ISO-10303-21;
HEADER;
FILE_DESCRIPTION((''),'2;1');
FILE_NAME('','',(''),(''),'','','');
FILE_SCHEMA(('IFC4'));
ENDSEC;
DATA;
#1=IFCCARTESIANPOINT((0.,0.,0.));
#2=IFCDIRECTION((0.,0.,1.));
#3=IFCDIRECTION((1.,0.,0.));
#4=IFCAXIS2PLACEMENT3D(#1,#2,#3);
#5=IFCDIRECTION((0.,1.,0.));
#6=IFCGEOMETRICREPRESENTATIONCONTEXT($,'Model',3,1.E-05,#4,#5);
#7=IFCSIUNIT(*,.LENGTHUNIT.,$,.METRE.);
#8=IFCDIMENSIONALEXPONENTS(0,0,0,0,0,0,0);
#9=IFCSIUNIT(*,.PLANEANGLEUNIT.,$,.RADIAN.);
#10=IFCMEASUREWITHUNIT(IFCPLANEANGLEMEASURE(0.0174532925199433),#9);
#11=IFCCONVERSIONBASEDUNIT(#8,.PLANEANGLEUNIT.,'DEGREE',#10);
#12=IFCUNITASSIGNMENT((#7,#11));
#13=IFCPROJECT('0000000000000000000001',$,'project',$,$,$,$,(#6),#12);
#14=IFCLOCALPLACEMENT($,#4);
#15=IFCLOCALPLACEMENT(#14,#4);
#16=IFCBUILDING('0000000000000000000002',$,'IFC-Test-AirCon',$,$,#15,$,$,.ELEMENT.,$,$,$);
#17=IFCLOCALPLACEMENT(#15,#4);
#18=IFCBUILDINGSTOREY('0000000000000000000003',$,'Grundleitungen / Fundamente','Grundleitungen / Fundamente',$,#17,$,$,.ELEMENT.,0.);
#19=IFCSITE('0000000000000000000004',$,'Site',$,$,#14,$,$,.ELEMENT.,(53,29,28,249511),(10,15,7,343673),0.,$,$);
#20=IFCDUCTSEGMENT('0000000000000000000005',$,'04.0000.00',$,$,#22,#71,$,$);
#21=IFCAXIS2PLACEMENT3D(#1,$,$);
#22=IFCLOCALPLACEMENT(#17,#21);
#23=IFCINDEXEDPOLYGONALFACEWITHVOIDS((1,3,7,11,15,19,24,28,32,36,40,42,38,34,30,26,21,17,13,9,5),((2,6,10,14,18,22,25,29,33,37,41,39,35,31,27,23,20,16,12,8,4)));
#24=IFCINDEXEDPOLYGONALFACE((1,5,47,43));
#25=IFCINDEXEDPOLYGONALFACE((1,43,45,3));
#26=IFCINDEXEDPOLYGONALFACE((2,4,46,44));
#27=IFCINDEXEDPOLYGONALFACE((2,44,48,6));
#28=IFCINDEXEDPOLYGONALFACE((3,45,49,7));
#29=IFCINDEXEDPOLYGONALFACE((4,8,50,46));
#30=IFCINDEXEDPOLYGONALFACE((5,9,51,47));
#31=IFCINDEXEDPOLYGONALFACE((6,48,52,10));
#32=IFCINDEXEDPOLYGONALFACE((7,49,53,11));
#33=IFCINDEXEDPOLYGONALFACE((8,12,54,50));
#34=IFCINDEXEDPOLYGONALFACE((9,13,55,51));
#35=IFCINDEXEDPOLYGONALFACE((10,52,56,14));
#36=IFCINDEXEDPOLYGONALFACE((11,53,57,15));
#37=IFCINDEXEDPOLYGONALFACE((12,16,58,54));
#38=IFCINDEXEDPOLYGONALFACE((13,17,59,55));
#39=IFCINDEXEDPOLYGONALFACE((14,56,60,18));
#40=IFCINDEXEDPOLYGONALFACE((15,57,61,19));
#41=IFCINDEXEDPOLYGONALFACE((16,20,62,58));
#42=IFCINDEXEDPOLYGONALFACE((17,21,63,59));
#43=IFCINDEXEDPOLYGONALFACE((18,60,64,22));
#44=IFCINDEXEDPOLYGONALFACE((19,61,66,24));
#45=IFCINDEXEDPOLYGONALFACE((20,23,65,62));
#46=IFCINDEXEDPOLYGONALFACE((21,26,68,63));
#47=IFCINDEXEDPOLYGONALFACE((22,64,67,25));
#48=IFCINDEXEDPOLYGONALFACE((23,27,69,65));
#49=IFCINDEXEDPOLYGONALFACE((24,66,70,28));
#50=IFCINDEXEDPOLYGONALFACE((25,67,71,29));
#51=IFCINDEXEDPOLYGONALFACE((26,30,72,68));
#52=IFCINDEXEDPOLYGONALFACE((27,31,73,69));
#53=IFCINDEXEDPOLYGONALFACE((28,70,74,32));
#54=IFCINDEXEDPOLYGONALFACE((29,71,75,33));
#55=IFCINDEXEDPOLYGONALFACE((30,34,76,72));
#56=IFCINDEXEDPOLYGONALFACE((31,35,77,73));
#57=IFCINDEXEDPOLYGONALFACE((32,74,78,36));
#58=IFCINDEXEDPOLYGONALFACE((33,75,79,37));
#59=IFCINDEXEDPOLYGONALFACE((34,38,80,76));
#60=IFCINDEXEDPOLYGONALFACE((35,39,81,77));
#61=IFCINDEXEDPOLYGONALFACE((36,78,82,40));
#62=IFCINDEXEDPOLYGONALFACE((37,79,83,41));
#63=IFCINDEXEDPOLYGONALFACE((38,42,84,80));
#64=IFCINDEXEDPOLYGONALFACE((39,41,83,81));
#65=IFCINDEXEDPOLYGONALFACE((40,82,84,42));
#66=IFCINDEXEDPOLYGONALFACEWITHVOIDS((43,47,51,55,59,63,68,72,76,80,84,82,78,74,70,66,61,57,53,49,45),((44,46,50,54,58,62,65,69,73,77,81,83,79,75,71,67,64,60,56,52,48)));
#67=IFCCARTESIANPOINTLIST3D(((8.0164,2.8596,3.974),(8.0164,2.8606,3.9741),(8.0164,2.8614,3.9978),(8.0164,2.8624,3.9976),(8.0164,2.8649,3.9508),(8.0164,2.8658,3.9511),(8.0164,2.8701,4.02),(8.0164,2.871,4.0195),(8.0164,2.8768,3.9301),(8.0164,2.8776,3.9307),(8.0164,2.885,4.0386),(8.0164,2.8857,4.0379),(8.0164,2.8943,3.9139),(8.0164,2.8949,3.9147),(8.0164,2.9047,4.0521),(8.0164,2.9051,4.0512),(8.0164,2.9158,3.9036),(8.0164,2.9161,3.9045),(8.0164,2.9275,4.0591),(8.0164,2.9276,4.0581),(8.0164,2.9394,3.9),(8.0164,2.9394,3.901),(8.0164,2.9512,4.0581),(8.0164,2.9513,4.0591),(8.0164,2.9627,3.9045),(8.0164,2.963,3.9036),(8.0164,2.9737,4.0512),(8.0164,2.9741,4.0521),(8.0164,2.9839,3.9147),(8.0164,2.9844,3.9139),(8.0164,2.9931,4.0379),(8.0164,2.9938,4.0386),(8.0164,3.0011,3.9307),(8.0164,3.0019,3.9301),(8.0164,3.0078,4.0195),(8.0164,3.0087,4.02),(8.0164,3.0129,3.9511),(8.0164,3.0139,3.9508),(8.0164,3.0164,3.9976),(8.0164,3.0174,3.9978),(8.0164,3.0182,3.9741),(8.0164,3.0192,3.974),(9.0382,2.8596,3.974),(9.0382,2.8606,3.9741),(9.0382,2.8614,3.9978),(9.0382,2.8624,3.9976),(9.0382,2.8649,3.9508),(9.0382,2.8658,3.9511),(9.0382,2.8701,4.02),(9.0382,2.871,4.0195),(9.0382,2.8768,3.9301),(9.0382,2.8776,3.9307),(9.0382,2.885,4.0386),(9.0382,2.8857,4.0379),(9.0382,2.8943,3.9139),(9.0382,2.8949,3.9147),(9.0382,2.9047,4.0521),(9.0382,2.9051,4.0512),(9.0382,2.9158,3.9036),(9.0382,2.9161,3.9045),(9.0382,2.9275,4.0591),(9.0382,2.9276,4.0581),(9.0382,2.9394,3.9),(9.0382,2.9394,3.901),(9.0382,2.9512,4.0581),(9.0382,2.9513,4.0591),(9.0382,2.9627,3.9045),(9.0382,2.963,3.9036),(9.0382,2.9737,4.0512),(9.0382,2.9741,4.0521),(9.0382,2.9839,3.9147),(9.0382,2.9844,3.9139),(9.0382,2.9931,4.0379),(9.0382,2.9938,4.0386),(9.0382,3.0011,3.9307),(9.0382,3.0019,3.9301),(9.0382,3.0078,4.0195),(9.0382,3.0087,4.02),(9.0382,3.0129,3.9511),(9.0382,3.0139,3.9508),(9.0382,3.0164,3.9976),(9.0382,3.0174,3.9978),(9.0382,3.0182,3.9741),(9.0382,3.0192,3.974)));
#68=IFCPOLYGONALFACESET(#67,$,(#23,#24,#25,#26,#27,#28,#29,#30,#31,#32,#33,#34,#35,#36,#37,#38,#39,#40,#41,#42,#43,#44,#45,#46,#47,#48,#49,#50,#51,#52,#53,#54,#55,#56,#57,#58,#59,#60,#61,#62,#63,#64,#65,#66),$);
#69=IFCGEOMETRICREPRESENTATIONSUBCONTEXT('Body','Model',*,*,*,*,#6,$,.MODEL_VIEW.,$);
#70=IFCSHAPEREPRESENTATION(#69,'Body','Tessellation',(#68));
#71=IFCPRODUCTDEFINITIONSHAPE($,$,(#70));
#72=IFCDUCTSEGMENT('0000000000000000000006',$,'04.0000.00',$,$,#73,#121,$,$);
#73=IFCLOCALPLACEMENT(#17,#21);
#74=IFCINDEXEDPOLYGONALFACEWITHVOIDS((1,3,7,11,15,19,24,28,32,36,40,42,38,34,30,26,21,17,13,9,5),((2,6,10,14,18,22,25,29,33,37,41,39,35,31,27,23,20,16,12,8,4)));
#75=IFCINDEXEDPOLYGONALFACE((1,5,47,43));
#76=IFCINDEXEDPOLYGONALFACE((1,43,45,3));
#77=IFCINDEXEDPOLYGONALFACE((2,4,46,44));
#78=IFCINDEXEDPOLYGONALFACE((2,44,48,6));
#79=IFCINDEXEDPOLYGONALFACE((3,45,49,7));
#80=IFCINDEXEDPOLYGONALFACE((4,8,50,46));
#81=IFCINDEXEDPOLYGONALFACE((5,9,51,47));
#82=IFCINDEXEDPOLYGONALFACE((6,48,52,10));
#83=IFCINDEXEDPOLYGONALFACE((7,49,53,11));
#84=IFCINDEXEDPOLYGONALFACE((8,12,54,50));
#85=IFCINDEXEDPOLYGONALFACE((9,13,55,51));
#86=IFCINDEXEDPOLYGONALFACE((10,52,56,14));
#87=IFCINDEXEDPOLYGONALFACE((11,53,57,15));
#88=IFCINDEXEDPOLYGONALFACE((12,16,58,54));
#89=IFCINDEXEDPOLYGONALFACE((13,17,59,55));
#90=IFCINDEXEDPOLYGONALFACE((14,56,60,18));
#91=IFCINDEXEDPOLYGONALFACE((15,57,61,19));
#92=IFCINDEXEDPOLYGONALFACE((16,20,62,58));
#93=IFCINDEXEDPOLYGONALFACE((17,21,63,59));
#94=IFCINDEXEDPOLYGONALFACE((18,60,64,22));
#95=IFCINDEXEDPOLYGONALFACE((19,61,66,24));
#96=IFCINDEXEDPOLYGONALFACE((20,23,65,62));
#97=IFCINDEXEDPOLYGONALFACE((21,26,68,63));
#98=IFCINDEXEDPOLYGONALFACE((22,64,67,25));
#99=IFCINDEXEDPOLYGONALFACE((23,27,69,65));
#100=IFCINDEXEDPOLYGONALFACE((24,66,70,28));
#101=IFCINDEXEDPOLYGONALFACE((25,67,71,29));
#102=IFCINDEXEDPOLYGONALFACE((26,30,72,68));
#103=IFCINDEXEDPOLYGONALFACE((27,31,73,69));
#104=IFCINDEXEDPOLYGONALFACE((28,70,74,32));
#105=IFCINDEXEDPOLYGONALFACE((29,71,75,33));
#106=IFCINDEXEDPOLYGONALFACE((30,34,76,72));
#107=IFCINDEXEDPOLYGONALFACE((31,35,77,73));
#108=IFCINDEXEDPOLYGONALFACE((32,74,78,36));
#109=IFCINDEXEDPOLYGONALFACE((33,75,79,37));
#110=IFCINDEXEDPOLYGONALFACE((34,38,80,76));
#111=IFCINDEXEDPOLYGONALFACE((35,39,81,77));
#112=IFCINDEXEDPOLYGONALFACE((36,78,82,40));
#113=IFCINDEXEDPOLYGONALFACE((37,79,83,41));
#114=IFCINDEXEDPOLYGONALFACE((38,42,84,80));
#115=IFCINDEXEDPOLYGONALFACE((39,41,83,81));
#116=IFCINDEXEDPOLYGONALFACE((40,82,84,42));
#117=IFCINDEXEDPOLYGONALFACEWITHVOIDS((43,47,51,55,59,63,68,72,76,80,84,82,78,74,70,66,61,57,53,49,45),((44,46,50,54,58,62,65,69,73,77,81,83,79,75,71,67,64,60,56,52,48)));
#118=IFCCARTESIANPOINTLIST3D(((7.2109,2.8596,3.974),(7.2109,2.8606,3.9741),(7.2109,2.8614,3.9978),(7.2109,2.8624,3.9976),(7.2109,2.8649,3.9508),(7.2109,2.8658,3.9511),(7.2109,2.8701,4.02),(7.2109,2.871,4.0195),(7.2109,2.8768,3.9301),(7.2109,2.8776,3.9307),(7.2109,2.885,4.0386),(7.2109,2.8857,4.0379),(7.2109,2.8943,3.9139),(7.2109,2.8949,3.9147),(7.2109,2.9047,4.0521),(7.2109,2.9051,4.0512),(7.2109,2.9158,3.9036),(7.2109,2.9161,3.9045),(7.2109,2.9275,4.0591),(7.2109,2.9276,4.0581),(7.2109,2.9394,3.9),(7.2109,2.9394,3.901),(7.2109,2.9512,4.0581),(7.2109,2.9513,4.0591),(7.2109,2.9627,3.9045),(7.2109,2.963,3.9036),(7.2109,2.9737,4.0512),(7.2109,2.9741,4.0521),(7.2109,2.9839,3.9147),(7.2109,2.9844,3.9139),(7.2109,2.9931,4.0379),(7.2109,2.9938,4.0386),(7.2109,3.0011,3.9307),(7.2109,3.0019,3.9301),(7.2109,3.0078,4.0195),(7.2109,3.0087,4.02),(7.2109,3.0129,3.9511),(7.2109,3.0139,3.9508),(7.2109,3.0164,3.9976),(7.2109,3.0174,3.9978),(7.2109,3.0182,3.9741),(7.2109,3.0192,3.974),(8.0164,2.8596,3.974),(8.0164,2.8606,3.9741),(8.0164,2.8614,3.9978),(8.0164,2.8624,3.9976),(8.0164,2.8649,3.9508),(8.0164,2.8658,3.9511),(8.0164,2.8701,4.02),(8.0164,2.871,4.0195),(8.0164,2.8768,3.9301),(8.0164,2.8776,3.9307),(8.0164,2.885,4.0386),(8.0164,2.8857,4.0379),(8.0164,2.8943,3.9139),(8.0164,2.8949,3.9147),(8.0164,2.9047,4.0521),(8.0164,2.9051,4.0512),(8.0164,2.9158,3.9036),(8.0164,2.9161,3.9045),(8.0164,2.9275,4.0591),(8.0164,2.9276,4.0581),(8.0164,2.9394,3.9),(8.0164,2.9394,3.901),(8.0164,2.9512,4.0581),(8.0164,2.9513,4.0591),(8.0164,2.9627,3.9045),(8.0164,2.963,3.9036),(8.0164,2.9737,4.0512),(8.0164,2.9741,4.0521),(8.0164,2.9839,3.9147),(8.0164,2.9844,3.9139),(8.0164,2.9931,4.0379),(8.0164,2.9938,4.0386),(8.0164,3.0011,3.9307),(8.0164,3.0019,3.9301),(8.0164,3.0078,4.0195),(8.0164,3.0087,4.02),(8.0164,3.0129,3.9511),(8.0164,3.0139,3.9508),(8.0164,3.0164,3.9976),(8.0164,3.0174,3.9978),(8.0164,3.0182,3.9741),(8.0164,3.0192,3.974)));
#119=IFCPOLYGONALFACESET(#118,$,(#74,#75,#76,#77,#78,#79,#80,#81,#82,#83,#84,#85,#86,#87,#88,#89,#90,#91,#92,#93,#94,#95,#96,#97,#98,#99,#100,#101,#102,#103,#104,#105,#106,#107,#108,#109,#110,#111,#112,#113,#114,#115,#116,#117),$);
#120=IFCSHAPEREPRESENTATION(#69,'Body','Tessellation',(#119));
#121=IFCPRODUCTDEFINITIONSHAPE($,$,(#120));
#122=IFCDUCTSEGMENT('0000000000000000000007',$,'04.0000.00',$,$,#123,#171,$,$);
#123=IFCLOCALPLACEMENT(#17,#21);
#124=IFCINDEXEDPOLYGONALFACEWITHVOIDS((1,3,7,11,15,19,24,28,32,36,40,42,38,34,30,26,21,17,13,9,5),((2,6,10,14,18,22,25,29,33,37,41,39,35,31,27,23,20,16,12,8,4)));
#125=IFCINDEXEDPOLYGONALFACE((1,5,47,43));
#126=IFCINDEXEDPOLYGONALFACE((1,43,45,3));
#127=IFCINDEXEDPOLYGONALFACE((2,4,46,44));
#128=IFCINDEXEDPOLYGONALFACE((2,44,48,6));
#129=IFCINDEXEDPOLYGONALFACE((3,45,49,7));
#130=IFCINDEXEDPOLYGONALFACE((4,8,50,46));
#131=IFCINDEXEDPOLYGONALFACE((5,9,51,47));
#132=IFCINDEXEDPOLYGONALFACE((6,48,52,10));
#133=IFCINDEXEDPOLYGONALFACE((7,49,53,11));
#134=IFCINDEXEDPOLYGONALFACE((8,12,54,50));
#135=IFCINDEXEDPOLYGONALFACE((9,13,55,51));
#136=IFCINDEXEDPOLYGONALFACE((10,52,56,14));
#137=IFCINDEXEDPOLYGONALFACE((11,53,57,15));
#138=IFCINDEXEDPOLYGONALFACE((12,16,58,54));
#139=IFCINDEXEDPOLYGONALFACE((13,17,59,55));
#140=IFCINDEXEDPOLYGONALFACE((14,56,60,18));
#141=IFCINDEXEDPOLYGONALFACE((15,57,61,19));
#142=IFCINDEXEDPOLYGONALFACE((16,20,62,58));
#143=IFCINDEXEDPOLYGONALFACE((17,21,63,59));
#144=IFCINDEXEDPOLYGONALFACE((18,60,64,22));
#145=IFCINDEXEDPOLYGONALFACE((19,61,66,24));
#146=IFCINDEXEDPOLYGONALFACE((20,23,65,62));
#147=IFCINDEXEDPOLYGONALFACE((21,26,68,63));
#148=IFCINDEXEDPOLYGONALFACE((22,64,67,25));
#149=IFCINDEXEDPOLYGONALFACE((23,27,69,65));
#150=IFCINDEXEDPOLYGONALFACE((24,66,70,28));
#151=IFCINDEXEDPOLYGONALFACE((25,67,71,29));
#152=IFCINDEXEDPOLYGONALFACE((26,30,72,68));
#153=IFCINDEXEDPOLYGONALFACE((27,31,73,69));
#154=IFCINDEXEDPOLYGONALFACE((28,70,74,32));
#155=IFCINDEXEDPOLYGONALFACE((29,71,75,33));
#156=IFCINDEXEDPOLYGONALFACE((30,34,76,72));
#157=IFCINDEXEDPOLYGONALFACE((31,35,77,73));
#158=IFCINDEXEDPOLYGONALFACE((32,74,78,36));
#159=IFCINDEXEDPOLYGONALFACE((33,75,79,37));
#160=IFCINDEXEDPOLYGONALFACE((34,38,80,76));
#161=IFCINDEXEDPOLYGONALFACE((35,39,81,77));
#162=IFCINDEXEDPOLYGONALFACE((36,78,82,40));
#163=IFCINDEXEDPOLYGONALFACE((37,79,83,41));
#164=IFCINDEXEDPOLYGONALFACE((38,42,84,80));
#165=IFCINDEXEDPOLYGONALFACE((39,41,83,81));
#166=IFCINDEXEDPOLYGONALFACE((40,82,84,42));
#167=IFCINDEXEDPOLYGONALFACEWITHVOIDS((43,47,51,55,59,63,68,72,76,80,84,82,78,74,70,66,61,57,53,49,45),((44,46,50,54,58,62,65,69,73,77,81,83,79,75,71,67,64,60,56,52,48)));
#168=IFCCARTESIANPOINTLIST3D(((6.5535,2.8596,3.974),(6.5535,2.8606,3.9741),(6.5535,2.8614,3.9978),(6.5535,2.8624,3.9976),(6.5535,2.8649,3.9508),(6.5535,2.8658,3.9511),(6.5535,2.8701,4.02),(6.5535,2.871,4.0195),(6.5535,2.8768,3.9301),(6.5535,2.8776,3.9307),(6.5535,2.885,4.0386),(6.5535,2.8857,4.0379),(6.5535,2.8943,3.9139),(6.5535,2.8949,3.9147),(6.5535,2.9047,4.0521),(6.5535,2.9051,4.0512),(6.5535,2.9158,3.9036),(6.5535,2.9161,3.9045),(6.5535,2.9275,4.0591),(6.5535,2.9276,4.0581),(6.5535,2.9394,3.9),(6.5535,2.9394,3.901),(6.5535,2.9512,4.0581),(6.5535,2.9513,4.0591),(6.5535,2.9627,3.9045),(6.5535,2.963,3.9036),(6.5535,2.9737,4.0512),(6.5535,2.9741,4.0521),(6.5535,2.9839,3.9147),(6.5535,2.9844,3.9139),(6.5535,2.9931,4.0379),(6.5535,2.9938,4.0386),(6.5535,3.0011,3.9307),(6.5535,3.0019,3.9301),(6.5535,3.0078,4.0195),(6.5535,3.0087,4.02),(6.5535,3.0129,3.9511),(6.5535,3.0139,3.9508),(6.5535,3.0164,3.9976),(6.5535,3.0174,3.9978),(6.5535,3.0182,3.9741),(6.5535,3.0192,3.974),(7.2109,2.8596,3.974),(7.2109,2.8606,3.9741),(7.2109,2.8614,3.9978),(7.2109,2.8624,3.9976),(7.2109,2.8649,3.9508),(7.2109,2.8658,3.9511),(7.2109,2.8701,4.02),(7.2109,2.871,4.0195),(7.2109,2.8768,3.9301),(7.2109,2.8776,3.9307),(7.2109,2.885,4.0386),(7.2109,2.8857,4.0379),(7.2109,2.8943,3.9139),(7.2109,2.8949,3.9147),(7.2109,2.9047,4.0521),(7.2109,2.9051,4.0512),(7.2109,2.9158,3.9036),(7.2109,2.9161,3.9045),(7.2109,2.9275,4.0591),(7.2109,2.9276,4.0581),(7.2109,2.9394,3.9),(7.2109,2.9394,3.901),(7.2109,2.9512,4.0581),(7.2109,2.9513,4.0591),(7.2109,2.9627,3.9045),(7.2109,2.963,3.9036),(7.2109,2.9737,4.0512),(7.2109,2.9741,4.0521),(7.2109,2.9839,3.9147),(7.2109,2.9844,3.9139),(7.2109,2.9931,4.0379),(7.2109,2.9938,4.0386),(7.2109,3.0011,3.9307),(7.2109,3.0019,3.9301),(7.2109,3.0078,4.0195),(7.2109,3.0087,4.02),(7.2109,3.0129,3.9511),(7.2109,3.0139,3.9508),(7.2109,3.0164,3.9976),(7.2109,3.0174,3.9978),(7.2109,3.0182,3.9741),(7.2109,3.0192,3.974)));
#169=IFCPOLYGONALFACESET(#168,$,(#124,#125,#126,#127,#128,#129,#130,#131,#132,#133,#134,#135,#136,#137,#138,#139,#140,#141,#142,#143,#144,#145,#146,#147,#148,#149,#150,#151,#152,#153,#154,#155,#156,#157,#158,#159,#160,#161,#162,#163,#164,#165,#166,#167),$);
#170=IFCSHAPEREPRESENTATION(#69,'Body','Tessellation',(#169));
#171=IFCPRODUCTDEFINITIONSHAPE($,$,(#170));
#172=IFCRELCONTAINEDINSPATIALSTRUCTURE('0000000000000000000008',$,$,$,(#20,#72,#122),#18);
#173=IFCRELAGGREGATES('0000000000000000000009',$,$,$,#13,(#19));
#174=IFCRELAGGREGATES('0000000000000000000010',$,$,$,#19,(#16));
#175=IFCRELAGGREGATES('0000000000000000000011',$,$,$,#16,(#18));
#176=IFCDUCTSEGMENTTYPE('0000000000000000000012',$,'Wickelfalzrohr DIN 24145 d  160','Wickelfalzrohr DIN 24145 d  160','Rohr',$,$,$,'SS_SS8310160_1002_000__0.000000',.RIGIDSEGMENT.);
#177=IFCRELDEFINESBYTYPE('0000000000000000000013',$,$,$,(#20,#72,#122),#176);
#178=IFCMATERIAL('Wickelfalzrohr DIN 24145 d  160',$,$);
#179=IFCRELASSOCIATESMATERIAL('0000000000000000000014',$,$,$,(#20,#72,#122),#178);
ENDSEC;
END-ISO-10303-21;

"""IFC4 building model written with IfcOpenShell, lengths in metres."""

from ifc_helpers import new_model, entity, si_unit, converted_unit, direction, frame, origin_with_axes, origin_2d_with_axis, place, context, subcontext, project, spatial, hollow_circle, extrude, material, type_object, element, save


model = new_model("IFC4")

# Units and contexts
model_context = context("Model", 3, precision=1e-05, world=origin_with_axes(), true_north=direction((0.0, 1.0, 0.0)))
body_context = subcontext(model_context, "Body", "Model", "MODEL_VIEW")
ifc_project = project(units=[si_unit("LENGTHUNIT", "METRE"), converted_unit("PLANEANGLEUNIT", "DEGREE", entity("IfcPlaneAngleMeasure", 0.0174532925199433), si_unit("PLANEANGLEUNIT", "RADIAN"), dimensions=[0, 0, 0, 0, 0, 0, 0])], contexts=[model_context])

# Site, building, storey
site_placement = place(None, origin_with_axes())
site = spatial("IfcSite", under=ifc_project, at=site_placement, Name="Site", CompositionType="ELEMENT", RefLatitude=(53, 29, 28, 249511), RefLongitude=(10, 15, 7, 343673), RefElevation=0.0)
building_placement = place(site_placement, origin_with_axes())
building = spatial("IfcBuilding", under=site, at=building_placement, Name="IFC-Test-AirCon", CompositionType="ELEMENT")
storey_placement = place(building_placement, origin_with_axes())
storey = spatial("IfcBuildingStorey", under=building, at=storey_placement, Name="Grundleitungen / Fundamente", Description="Grundleitungen / Fundamente", CompositionType="ELEMENT", Elevation=0.0)

# Duct segments
ifc_material_1 = material(Name="Wickelfalzrohr DIN 24145 d  160")
duct_segment_type_1 = type_object("IfcDuctSegmentType", Name="Wickelfalzrohr DIN 24145 d  160", Description="Wickelfalzrohr DIN 24145 d  160", ApplicableOccurrence="Rohr", ElementType="SS_SS8310160_1002_000__0.000000", PredefinedType="RIGIDSEGMENT")
duct_segment_1_placement = place(storey_placement, frame((9.0382, 2.9394, 3.98), z_axis=(0.0, 0.0, 1.0), x_axis=(-1.0, 0.0, 0.0)))
element("IfcDuctSegment", 1, at=duct_segment_1_placement, inside=storey, type_object=duct_segment_type_1, material=ifc_material_1, Name="04.0000.00", context=body_context, shape_type="SweptSolid", body=[
    extrude(hollow_circle(Radius=0.08, WallThickness=0.001, at=origin_2d_with_axis()), frame((0.0, 0.0, 0.0), z_axis=(1.0, 0.0, 0.0), x_axis=(0.0, 0.0, -1.0)), (0.0, 0.0, 1.0), 1.0218),
])
duct_segment_2_placement = place(storey_placement, frame((8.0164, 2.9394, 3.98), z_axis=(0.0, 0.0, 1.0), x_axis=(-1.0, 0.0, 0.0)))
element("IfcDuctSegment", 2, at=duct_segment_2_placement, inside=storey, type_object=duct_segment_type_1, material=ifc_material_1, Name="04.0000.00", context=body_context, shape_type="SweptSolid", body=[
    extrude(hollow_circle(Radius=0.08, WallThickness=0.001, at=origin_2d_with_axis()), frame((0.0, 0.0, 0.0), z_axis=(1.0, 0.0, 0.0), x_axis=(0.0, 0.0, -1.0)), (0.0, 0.0, 1.0), 0.8055),
])
duct_segment_3_placement = place(storey_placement, frame((7.2109, 2.9394, 3.98), z_axis=(0.0, 0.0, 1.0), x_axis=(-1.0, 0.0, 0.0)))
element("IfcDuctSegment", 3, at=duct_segment_3_placement, inside=storey, type_object=duct_segment_type_1, material=ifc_material_1, Name="04.0000.00", context=body_context, shape_type="SweptSolid", body=[
    extrude(hollow_circle(Radius=0.08, WallThickness=0.001, at=origin_2d_with_axis()), frame((0.0, 0.0, 0.0), z_axis=(1.0, 0.0, 0.0), x_axis=(0.0, 0.0, -1.0)), (0.0, 0.0, 1.0), 0.6574),
])

save(model, "model.ifc")
